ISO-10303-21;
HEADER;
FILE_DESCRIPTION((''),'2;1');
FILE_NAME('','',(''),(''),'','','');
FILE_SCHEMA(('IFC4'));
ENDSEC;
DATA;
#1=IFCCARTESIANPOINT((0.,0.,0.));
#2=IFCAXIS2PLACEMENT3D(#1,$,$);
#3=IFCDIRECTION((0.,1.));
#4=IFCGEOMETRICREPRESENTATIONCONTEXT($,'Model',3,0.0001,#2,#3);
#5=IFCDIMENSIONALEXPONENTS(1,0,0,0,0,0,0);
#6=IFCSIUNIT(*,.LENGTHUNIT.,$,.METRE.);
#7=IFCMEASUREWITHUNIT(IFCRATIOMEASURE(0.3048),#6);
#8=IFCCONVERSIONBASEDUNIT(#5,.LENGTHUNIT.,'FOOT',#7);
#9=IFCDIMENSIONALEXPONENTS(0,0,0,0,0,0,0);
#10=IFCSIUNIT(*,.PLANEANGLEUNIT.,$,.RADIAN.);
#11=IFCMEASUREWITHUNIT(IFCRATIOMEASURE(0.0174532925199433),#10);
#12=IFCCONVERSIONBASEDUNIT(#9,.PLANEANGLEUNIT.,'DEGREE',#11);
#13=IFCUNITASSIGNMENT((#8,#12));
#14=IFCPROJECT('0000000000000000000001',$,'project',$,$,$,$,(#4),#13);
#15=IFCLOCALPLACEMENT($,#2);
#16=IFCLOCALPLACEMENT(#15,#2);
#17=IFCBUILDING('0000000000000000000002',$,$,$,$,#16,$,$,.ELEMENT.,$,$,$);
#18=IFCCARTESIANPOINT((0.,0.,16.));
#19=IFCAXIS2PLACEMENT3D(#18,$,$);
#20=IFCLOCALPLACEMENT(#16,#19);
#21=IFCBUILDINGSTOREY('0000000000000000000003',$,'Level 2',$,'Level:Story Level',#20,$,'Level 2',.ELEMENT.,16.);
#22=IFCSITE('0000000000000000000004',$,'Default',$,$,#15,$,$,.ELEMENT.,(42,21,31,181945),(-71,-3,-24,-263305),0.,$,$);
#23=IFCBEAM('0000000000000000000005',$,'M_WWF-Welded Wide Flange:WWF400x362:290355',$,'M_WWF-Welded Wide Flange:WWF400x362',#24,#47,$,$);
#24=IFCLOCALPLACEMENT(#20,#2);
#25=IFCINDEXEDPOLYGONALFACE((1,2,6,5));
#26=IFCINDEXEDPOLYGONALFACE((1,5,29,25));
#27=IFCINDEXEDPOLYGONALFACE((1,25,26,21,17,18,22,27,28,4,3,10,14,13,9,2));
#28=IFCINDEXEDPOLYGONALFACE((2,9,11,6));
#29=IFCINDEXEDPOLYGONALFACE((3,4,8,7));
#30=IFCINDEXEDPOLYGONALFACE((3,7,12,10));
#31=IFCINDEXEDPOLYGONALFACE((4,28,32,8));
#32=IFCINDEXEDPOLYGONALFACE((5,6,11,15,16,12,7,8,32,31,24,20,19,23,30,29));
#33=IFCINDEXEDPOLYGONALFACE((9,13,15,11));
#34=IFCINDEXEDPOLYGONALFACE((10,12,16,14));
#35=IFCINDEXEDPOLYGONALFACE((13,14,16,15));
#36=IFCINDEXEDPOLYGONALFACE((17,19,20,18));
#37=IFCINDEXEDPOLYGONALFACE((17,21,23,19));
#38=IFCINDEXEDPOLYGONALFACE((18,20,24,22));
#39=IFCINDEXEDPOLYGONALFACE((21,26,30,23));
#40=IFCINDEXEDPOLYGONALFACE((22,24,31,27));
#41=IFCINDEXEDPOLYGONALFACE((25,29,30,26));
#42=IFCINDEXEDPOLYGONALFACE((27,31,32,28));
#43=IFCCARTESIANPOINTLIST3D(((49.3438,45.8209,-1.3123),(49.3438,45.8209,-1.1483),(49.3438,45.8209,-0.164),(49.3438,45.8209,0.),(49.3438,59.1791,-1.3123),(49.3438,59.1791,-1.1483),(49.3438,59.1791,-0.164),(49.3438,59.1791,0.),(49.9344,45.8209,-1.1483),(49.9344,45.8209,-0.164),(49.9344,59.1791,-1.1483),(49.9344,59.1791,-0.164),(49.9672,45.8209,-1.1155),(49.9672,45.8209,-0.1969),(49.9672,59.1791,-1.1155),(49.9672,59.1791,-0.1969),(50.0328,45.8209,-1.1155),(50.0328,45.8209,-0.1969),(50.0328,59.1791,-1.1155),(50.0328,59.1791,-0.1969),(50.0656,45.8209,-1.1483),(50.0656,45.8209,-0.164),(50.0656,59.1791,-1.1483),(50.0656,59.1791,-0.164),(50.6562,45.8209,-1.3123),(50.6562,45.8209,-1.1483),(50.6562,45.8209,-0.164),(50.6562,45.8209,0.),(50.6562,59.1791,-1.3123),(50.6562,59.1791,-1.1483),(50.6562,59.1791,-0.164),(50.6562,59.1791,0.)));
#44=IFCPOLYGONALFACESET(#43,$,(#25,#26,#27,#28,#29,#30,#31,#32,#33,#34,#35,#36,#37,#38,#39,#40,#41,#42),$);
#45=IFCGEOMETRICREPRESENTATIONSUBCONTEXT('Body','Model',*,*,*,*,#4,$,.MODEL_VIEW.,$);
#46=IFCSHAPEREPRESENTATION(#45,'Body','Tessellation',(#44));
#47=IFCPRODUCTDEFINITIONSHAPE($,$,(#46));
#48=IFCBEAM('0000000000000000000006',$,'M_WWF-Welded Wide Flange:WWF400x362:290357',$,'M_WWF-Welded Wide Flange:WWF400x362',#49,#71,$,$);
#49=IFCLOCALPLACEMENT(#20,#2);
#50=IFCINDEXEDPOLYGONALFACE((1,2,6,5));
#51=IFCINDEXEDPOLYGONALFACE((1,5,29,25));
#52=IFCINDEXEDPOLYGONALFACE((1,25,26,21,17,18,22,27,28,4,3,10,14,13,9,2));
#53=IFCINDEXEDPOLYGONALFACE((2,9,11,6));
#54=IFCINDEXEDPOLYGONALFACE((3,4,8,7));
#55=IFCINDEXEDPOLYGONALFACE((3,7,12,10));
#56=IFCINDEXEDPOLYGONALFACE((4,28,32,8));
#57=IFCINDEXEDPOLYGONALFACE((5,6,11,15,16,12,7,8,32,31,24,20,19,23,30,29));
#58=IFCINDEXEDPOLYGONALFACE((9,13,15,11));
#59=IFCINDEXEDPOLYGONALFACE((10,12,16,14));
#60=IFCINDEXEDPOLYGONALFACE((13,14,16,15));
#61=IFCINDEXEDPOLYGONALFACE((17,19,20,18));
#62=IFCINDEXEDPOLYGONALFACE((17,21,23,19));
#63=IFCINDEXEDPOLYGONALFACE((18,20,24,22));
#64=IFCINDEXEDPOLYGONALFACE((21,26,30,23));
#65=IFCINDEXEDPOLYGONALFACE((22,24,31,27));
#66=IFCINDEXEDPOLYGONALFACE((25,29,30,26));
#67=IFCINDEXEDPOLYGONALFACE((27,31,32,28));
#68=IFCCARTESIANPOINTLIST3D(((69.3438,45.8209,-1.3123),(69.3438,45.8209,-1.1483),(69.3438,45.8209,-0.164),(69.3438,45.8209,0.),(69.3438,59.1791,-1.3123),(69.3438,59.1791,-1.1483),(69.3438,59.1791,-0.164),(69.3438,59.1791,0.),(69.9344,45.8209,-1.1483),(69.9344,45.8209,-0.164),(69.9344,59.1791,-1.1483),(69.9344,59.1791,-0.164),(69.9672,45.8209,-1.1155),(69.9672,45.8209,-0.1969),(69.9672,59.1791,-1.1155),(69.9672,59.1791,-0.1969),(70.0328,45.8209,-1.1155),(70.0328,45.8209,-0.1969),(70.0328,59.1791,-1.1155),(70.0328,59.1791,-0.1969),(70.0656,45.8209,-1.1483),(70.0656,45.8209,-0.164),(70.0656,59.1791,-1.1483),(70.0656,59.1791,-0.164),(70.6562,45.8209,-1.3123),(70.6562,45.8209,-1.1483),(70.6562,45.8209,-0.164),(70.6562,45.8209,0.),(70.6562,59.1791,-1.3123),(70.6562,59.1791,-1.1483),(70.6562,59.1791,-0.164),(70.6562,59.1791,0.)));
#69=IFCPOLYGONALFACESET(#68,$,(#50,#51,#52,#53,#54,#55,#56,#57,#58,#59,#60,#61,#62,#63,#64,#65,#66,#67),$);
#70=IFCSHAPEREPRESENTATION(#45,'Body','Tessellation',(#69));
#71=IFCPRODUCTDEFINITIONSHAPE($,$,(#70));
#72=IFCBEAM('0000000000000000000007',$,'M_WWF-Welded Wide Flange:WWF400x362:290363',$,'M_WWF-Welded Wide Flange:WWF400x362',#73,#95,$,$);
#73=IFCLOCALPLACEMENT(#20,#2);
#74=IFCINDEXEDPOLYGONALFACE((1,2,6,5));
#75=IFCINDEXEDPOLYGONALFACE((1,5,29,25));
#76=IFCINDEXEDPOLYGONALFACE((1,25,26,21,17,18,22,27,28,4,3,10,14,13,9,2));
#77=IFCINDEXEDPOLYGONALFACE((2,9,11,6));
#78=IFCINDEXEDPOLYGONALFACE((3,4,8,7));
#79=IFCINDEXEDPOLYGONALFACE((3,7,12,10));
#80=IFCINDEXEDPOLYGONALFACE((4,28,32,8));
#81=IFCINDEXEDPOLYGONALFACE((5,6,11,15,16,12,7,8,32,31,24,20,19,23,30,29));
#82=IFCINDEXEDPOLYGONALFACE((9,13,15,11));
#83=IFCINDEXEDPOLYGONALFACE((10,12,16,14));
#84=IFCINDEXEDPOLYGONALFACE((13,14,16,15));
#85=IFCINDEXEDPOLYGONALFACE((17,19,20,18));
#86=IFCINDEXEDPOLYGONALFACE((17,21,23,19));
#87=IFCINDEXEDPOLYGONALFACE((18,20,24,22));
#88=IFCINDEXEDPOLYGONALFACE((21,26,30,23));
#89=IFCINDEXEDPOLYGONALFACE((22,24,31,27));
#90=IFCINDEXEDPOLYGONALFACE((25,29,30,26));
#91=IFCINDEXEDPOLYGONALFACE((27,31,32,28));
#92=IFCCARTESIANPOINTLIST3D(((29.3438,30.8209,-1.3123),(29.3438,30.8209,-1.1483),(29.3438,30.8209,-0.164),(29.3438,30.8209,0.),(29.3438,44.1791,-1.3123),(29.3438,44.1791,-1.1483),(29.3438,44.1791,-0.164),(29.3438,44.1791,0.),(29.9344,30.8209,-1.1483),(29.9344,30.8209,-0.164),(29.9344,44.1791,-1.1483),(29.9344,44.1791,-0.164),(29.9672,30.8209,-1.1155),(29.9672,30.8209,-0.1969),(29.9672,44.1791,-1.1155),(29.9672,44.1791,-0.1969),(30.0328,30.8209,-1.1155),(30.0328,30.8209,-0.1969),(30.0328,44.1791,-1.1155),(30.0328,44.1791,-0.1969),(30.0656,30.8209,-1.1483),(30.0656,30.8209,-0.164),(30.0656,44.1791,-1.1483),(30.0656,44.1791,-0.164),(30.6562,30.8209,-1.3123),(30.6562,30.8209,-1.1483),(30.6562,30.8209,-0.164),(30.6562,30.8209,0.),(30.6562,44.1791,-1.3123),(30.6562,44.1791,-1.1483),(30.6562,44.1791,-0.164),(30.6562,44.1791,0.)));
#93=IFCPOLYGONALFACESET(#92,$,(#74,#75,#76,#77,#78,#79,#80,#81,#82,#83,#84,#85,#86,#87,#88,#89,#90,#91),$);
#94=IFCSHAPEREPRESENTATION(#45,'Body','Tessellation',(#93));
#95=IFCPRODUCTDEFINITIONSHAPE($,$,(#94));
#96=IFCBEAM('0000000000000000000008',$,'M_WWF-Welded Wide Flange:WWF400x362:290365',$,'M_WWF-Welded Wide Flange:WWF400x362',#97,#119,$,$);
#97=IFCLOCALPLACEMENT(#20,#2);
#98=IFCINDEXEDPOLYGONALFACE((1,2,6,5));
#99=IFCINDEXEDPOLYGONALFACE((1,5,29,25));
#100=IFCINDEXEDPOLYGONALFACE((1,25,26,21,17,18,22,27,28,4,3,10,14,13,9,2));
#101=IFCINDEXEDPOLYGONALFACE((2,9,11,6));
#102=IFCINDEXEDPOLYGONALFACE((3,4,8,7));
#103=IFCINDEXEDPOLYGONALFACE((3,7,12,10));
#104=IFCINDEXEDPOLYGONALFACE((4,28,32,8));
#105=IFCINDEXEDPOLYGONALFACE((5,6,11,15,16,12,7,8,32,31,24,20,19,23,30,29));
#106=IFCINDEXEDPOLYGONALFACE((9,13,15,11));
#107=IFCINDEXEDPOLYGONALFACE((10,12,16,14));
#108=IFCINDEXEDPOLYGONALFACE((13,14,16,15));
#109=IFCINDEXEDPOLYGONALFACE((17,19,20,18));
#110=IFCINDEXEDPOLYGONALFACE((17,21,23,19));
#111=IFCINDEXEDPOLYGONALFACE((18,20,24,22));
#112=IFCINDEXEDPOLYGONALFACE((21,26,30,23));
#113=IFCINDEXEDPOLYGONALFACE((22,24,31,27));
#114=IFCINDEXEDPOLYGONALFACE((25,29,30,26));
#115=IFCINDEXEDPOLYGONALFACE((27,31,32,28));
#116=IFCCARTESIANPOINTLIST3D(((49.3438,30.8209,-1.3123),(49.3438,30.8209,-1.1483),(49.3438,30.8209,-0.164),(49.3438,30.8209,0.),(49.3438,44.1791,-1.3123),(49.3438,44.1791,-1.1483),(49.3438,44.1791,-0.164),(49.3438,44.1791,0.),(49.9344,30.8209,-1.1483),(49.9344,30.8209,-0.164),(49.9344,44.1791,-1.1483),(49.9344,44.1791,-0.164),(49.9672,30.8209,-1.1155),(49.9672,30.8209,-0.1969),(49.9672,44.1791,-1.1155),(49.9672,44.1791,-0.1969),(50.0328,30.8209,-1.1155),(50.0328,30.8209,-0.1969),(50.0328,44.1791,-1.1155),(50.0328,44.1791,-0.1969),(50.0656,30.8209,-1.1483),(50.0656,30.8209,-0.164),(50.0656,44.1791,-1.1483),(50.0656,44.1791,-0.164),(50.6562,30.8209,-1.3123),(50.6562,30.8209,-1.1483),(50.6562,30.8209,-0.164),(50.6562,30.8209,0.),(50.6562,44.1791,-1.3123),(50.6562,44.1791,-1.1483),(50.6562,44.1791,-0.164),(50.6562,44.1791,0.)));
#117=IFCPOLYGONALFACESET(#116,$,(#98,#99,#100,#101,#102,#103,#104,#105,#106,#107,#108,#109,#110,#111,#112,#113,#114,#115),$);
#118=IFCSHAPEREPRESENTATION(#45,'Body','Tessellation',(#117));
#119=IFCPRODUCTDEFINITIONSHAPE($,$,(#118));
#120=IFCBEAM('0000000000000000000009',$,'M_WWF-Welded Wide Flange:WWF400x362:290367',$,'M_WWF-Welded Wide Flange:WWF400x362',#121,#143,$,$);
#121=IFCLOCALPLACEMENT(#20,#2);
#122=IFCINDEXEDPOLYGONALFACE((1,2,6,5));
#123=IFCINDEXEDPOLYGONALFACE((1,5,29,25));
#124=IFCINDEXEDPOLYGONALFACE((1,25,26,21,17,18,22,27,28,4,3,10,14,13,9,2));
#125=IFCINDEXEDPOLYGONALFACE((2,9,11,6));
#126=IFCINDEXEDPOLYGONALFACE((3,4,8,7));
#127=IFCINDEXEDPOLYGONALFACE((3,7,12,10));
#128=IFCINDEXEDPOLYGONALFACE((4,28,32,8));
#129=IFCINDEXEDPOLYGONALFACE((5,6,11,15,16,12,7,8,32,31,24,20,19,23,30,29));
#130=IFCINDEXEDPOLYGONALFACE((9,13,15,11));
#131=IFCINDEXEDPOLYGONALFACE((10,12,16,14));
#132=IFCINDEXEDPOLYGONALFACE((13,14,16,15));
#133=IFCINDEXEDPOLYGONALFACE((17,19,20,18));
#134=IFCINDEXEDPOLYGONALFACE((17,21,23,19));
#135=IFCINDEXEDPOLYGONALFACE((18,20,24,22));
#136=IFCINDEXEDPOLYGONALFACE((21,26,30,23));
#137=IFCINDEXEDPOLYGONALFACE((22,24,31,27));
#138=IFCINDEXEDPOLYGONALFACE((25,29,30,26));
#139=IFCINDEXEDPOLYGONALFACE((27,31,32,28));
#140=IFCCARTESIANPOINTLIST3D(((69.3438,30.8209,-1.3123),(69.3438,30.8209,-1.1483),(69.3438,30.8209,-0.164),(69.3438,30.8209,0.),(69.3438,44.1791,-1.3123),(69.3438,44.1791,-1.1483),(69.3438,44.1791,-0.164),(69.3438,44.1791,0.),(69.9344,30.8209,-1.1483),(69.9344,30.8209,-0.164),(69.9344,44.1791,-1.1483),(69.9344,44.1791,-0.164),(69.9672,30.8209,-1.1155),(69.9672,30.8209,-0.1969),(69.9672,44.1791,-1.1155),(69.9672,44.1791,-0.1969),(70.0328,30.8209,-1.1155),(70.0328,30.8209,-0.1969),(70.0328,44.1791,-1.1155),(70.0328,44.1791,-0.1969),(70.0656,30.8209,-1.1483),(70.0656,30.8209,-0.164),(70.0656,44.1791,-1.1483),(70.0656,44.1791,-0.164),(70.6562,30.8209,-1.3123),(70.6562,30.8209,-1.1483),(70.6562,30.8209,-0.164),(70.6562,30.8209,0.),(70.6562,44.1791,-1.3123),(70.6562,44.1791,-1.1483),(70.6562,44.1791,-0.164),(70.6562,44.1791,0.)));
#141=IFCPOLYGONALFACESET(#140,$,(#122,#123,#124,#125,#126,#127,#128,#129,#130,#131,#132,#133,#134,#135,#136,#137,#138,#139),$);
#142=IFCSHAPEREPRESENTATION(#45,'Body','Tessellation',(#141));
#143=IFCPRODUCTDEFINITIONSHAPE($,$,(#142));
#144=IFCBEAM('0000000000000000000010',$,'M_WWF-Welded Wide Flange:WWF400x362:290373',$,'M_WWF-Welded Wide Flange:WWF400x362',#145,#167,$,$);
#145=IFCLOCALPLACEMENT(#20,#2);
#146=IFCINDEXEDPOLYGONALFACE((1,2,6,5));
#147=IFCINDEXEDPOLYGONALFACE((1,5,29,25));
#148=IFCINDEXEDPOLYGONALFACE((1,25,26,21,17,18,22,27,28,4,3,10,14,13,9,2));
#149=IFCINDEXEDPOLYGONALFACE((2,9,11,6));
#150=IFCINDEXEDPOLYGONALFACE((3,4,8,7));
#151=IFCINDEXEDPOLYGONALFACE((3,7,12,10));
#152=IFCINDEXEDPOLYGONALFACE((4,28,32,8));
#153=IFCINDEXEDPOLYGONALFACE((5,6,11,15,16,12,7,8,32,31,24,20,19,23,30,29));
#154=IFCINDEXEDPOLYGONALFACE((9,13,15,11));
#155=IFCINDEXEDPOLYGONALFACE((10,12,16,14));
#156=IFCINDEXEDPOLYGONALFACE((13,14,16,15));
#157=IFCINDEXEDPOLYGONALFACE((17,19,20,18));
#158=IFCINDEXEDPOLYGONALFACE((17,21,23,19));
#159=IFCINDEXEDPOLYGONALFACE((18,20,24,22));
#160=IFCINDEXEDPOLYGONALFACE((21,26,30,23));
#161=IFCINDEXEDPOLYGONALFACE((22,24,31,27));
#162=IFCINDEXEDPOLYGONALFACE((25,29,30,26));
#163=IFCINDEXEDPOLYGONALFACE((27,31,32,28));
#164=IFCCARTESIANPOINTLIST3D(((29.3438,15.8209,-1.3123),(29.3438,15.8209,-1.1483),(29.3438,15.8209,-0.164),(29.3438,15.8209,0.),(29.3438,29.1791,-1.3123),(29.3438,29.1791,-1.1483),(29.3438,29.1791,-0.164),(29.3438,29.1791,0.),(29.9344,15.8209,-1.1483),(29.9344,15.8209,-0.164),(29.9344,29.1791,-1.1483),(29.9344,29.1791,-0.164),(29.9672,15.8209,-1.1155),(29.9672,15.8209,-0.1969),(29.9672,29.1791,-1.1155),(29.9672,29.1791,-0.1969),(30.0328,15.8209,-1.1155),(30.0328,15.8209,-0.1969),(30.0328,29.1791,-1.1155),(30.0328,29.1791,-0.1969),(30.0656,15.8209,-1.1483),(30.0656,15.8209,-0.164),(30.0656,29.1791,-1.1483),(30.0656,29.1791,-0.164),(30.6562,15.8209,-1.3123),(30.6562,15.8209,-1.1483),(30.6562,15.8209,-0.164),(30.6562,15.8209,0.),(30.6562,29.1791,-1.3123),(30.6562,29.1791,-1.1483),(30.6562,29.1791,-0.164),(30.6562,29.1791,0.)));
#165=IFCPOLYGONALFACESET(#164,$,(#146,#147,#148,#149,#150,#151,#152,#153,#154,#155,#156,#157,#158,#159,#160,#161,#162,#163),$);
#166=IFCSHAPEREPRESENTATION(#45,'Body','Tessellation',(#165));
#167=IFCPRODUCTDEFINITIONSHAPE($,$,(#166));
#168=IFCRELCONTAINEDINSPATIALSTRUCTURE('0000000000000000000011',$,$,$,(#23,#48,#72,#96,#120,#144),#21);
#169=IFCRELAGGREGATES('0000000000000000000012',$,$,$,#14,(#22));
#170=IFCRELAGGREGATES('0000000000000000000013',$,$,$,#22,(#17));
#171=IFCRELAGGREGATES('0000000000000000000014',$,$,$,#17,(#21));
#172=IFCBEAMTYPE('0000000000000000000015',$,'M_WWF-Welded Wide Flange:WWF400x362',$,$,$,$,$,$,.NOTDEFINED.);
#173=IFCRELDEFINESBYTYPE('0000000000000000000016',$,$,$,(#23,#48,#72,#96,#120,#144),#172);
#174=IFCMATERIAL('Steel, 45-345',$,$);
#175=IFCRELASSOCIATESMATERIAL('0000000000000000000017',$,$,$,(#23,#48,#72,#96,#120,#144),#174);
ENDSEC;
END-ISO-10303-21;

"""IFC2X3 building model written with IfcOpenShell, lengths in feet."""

from ifc_helpers import new_model, entity, si_unit, converted_unit, direction, frame, origin, place, context, subcontext, project, spatial, polyline, outline, extrude, material, type_object, element, save


model = new_model("IFC2X3")

# Units and contexts
model_context = context("Model", 3, precision=0.0001, world=origin(), true_north=direction((0.0, 1.0)))
body_context = subcontext(model_context, "Body", "Model", "MODEL_VIEW")
ifc_project = project(units=[converted_unit("LENGTHUNIT", "FOOT", entity("IfcRatioMeasure", 0.3048), si_unit("LENGTHUNIT", "METRE"), dimensions=[1, 0, 0, 0, 0, 0, 0]), converted_unit("PLANEANGLEUNIT", "DEGREE", entity("IfcRatioMeasure", 0.0174532925199433), si_unit("PLANEANGLEUNIT", "RADIAN"), dimensions=[0, 0, 0, 0, 0, 0, 0])], contexts=[model_context])

# Site, building, storey
site_placement = place(None, origin())
site = spatial("IfcSite", under=ifc_project, at=site_placement, Name="Default", CompositionType="ELEMENT", RefLatitude=(42, 21, 31, 181945), RefLongitude=(-71, -3, -24, -263305), RefElevation=0.0)
building_placement = place(site_placement, origin())
building = spatial("IfcBuilding", under=site, at=building_placement, CompositionType="ELEMENT")
storey_placement = place(building_placement, frame((0.0, 0.0, 16.0)))
storey = spatial("IfcBuildingStorey", under=building, at=storey_placement, Name="Level 2", ObjectType="Level:Story Level", LongName="Level 2", CompositionType="ELEMENT", Elevation=16.0)

# Shared definitions
ifc_material = material(Name="Steel, 45-345")

# Beams
beam_type = type_object("IfcBeamType", Name="M_WWF-Welded Wide Flange:WWF400x362", PredefinedType="NOTDEFINED")
beam_1_placement = place(storey_placement, frame((50.0, 45.0, 0.0), z_axis=(0.0, 0.0, 1.0), x_axis=(0.0, 1.0, 0.0)))
element("IfcBeam", 1, at=beam_1_placement, inside=storey, type_object=beam_type, material=ifc_material, Name="M_WWF-Welded Wide Flange:WWF400x362:290355", ObjectType="M_WWF-Welded Wide Flange:WWF400x362", context=body_context, shape_type="SweptSolid", body=[
    extrude(outline(polyline([(-0.6562, -0.6562), (-0.4921, -0.6562), (-0.4921, -0.0656), (-0.4593, -0.0328), (0.4593, -0.0328), (0.4921, -0.0656), (0.4921, -0.6562), (0.6562, -0.6562), (0.6562, 0.6562), (0.4921, 0.6562), (0.4921, 0.0656), (0.4593, 0.0328), (-0.4593, 0.0328), (-0.4921, 0.0656), (-0.4921, 0.6562), (-0.6562, 0.6562), (-0.6562, -0.6562)])), frame((0.8209, 0.0, -0.6562), z_axis=(1.0, 0.0, 0.0), x_axis=(0.0, 0.0, -1.0)), (0.0, 0.0, 1.0), 13.3583),
])
beam_2_placement = place(storey_placement, frame((70.0, 45.0, 0.0), z_axis=(0.0, 0.0, 1.0), x_axis=(0.0, 1.0, 0.0)))
element("IfcBeam", 2, at=beam_2_placement, inside=storey, type_object=beam_type, material=ifc_material, Name="M_WWF-Welded Wide Flange:WWF400x362:290357", ObjectType="M_WWF-Welded Wide Flange:WWF400x362", context=body_context, shape_type="SweptSolid", body=[
    extrude(outline(polyline([(-0.6562, -0.6562), (-0.4921, -0.6562), (-0.4921, -0.0656), (-0.4593, -0.0328), (0.4593, -0.0328), (0.4921, -0.0656), (0.4921, -0.6562), (0.6562, -0.6562), (0.6562, 0.6562), (0.4921, 0.6562), (0.4921, 0.0656), (0.4593, 0.0328), (-0.4593, 0.0328), (-0.4921, 0.0656), (-0.4921, 0.6562), (-0.6562, 0.6562), (-0.6562, -0.6562)])), frame((0.8209, 0.0, -0.6562), z_axis=(1.0, 0.0, 0.0), x_axis=(0.0, 0.0, -1.0)), (0.0, 0.0, 1.0), 13.3583),
])
beam_3_placement = place(storey_placement, frame((30.0, 30.0, 0.0), z_axis=(0.0, 0.0, 1.0), x_axis=(0.0, 1.0, 0.0)))
element("IfcBeam", 3, at=beam_3_placement, inside=storey, type_object=beam_type, material=ifc_material, Name="M_WWF-Welded Wide Flange:WWF400x362:290363", ObjectType="M_WWF-Welded Wide Flange:WWF400x362", context=body_context, shape_type="SweptSolid", body=[
    extrude(outline(polyline([(-0.6562, -0.6562), (-0.4921, -0.6562), (-0.4921, -0.0656), (-0.4593, -0.0328), (0.4593, -0.0328), (0.4921, -0.0656), (0.4921, -0.6562), (0.6562, -0.6562), (0.6562, 0.6562), (0.4921, 0.6562), (0.4921, 0.0656), (0.4593, 0.0328), (-0.4593, 0.0328), (-0.4921, 0.0656), (-0.4921, 0.6562), (-0.6562, 0.6562), (-0.6562, -0.6562)])), frame((0.8209, 0.0, -0.6562), z_axis=(1.0, 0.0, 0.0), x_axis=(0.0, 0.0, -1.0)), (0.0, 0.0, 1.0), 13.3583),
])
beam_4_placement = place(storey_placement, frame((50.0, 30.0, 0.0), z_axis=(0.0, 0.0, 1.0), x_axis=(0.0, 1.0, 0.0)))
element("IfcBeam", 4, at=beam_4_placement, inside=storey, type_object=beam_type, material=ifc_material, Name="M_WWF-Welded Wide Flange:WWF400x362:290365", ObjectType="M_WWF-Welded Wide Flange:WWF400x362", context=body_context, shape_type="SweptSolid", body=[
    extrude(outline(polyline([(-0.6562, -0.6562), (-0.4921, -0.6562), (-0.4921, -0.0656), (-0.4593, -0.0328), (0.4593, -0.0328), (0.4921, -0.0656), (0.4921, -0.6562), (0.6562, -0.6562), (0.6562, 0.6562), (0.4921, 0.6562), (0.4921, 0.0656), (0.4593, 0.0328), (-0.4593, 0.0328), (-0.4921, 0.0656), (-0.4921, 0.6562), (-0.6562, 0.6562), (-0.6562, -0.6562)])), frame((0.8209, 0.0, -0.6562), z_axis=(1.0, 0.0, 0.0), x_axis=(0.0, 0.0, -1.0)), (0.0, 0.0, 1.0), 13.3583),
])
beam_5_placement = place(storey_placement, frame((70.0, 30.0, 0.0), z_axis=(0.0, 0.0, 1.0), x_axis=(0.0, 1.0, 0.0)))
element("IfcBeam", 5, at=beam_5_placement, inside=storey, type_object=beam_type, material=ifc_material, Name="M_WWF-Welded Wide Flange:WWF400x362:290367", ObjectType="M_WWF-Welded Wide Flange:WWF400x362", context=body_context, shape_type="SweptSolid", body=[
    extrude(outline(polyline([(-0.6562, -0.6562), (-0.4921, -0.6562), (-0.4921, -0.0656), (-0.4593, -0.0328), (0.4593, -0.0328), (0.4921, -0.0656), (0.4921, -0.6562), (0.6562, -0.6562), (0.6562, 0.6562), (0.4921, 0.6562), (0.4921, 0.0656), (0.4593, 0.0328), (-0.4593, 0.0328), (-0.4921, 0.0656), (-0.4921, 0.6562), (-0.6562, 0.6562), (-0.6562, -0.6562)])), frame((0.8209, 0.0, -0.6562), z_axis=(1.0, 0.0, 0.0), x_axis=(0.0, 0.0, -1.0)), (0.0, 0.0, 1.0), 13.3583),
])
beam_6_placement = place(storey_placement, frame((30.0, 15.0, 0.0), z_axis=(0.0, 0.0, 1.0), x_axis=(0.0, 1.0, 0.0)))
element("IfcBeam", 6, at=beam_6_placement, inside=storey, type_object=beam_type, material=ifc_material, Name="M_WWF-Welded Wide Flange:WWF400x362:290373", ObjectType="M_WWF-Welded Wide Flange:WWF400x362", context=body_context, shape_type="SweptSolid", body=[
    extrude(outline(polyline([(-0.6562, -0.6562), (-0.4921, -0.6562), (-0.4921, -0.0656), (-0.4593, -0.0328), (0.4593, -0.0328), (0.4921, -0.0656), (0.4921, -0.6562), (0.6562, -0.6562), (0.6562, 0.6562), (0.4921, 0.6562), (0.4921, 0.0656), (0.4593, 0.0328), (-0.4593, 0.0328), (-0.4921, 0.0656), (-0.4921, 0.6562), (-0.6562, 0.6562), (-0.6562, -0.6562)])), frame((0.8209, 0.0, -0.6562), z_axis=(1.0, 0.0, 0.0), x_axis=(0.0, 0.0, -1.0)), (0.0, 0.0, 1.0), 13.3583),
])

save(model, "model.ifc")
